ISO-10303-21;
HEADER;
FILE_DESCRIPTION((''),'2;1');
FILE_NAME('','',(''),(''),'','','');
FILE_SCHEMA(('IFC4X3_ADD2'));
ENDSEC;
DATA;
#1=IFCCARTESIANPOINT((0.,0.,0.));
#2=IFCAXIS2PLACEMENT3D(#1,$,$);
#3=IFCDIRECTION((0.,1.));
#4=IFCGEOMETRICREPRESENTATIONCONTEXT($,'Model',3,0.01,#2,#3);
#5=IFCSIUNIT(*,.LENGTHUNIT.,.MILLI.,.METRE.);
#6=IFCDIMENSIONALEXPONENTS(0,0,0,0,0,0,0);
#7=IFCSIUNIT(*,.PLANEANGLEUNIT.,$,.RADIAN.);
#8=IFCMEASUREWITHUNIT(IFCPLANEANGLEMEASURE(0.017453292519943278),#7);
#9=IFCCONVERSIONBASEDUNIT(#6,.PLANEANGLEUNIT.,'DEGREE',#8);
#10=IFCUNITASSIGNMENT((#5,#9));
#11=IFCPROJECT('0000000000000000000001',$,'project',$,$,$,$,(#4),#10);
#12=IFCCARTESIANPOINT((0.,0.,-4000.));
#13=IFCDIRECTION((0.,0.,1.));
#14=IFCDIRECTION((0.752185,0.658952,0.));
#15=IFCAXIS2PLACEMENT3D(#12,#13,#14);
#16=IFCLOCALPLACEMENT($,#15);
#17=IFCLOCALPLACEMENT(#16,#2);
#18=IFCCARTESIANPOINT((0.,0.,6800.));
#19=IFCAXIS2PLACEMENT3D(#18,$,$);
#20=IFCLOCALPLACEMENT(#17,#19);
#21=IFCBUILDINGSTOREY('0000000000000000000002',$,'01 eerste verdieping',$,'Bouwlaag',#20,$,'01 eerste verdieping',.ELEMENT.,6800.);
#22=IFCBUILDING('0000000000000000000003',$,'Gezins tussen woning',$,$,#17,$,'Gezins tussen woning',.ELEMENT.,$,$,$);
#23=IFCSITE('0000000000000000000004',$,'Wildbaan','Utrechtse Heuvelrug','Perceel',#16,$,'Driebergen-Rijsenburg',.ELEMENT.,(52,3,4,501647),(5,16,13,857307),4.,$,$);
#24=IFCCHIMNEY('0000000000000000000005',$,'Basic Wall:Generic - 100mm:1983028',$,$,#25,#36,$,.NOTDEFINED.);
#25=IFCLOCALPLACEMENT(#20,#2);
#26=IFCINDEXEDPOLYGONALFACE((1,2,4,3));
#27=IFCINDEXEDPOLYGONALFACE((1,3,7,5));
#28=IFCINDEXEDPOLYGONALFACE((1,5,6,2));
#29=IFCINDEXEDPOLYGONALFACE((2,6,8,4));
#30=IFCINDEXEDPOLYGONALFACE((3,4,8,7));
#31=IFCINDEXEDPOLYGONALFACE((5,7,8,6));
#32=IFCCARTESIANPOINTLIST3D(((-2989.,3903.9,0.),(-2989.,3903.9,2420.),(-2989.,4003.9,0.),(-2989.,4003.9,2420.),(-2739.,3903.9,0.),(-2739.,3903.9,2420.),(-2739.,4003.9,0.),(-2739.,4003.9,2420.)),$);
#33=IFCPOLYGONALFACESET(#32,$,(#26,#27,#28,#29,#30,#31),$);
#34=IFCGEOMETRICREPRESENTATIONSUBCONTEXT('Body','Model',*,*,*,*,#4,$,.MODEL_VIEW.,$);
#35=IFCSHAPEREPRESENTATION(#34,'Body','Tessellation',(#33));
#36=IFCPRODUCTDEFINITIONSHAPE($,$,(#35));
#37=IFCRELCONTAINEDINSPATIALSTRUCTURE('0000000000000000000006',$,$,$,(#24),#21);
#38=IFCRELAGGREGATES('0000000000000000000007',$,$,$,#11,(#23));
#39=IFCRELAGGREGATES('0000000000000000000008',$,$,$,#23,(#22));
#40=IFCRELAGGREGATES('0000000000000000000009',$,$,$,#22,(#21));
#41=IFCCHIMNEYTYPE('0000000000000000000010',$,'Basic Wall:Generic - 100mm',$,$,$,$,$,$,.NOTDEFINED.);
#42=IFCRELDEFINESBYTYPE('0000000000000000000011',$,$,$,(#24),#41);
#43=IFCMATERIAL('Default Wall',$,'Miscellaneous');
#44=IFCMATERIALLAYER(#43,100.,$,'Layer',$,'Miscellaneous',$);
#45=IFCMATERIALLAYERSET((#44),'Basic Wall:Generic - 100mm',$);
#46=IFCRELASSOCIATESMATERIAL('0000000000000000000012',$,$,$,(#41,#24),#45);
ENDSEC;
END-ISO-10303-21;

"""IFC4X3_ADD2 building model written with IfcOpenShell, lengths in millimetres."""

from ifc_helpers import new_model, entity, si_unit, converted_unit, direction, frame, frame_2d, origin, place, context, subcontext, project, spatial, rectangle, extrude, material, layer, layer_set, layer_usage, type_object, element, save


model = new_model("IFC4X3_ADD2")

# Units and contexts
model_context = context("Model", 3, precision=0.01, world=origin(), true_north=direction((0.0, 1.0)))
body_context = subcontext(model_context, "Body", "Model", "MODEL_VIEW")
ifc_project = project(units=[si_unit("LENGTHUNIT", "METRE", prefix="MILLI"), converted_unit("PLANEANGLEUNIT", "DEGREE", entity("IfcPlaneAngleMeasure", 0.017453292519943278), si_unit("PLANEANGLEUNIT", "RADIAN"), dimensions=[0, 0, 0, 0, 0, 0, 0])], contexts=[model_context])

# Site, building, storey
site_placement = place(None, frame((0.0, 0.0, -4000.0), z_axis=(0.0, 0.0, 1.0), x_axis=(0.752185, 0.658952, 0.0)))
site = spatial("IfcSite", under=ifc_project, at=site_placement, Name="Wildbaan", Description="Utrechtse Heuvelrug", ObjectType="Perceel", LongName="Driebergen-Rijsenburg", CompositionType="ELEMENT", RefLatitude=(52, 3, 4, 501647), RefLongitude=(5, 16, 13, 857307), RefElevation=4.0)
building_placement = place(site_placement, origin())
building = spatial("IfcBuilding", under=site, at=building_placement, Name="Gezins tussen woning", LongName="Gezins tussen woning", CompositionType="ELEMENT")
storey_placement = place(building_placement, frame((0.0, 0.0, 6800.0)))
storey = spatial("IfcBuildingStorey", under=building, at=storey_placement, Name="01 eerste verdieping", ObjectType="Bouwlaag", LongName="01 eerste verdieping", CompositionType="ELEMENT", Elevation=6800.0)

# Shared definitions
ifc_material_1 = material(Name="Default Wall", Category="Miscellaneous")

# Chimney
ifc_layer_1 = layer(ifc_material_1, 100.0, Name="Layer", Category="Miscellaneous")
ifc_layer_set_1 = layer_set([ifc_layer_1], Name="Basic Wall:Generic - 100mm")
chimney_type = type_object("IfcChimneyType", Name="Basic Wall:Generic - 100mm", PredefinedType="NOTDEFINED", material=ifc_layer_set_1)
ifc_layer_usage_1 = layer_usage(ifc_layer_set_1, "AXIS2", "NEGATIVE", 50.0)
chimney_1_placement = place(storey_placement, frame((-2739.0, 3953.9, 0.0), z_axis=(0.0, 0.0, 1.0), x_axis=(-1.0, 0.0, 0.0)))
element("IfcChimney", 1, at=chimney_1_placement, inside=storey, type_object=chimney_type, material=ifc_layer_usage_1, Name="Basic Wall:Generic - 100mm:1983028", PredefinedType="NOTDEFINED", context=body_context, shape_type="SweptSolid", body=[
    extrude(rectangle(XDim=250.0, YDim=100.0, at=frame_2d((125.0, 0.0), x_axis=(-1.0, 0.0))), origin(), (0.0, 0.0, 1.0), 2420.0),
])

save(model, "model.ifc")
